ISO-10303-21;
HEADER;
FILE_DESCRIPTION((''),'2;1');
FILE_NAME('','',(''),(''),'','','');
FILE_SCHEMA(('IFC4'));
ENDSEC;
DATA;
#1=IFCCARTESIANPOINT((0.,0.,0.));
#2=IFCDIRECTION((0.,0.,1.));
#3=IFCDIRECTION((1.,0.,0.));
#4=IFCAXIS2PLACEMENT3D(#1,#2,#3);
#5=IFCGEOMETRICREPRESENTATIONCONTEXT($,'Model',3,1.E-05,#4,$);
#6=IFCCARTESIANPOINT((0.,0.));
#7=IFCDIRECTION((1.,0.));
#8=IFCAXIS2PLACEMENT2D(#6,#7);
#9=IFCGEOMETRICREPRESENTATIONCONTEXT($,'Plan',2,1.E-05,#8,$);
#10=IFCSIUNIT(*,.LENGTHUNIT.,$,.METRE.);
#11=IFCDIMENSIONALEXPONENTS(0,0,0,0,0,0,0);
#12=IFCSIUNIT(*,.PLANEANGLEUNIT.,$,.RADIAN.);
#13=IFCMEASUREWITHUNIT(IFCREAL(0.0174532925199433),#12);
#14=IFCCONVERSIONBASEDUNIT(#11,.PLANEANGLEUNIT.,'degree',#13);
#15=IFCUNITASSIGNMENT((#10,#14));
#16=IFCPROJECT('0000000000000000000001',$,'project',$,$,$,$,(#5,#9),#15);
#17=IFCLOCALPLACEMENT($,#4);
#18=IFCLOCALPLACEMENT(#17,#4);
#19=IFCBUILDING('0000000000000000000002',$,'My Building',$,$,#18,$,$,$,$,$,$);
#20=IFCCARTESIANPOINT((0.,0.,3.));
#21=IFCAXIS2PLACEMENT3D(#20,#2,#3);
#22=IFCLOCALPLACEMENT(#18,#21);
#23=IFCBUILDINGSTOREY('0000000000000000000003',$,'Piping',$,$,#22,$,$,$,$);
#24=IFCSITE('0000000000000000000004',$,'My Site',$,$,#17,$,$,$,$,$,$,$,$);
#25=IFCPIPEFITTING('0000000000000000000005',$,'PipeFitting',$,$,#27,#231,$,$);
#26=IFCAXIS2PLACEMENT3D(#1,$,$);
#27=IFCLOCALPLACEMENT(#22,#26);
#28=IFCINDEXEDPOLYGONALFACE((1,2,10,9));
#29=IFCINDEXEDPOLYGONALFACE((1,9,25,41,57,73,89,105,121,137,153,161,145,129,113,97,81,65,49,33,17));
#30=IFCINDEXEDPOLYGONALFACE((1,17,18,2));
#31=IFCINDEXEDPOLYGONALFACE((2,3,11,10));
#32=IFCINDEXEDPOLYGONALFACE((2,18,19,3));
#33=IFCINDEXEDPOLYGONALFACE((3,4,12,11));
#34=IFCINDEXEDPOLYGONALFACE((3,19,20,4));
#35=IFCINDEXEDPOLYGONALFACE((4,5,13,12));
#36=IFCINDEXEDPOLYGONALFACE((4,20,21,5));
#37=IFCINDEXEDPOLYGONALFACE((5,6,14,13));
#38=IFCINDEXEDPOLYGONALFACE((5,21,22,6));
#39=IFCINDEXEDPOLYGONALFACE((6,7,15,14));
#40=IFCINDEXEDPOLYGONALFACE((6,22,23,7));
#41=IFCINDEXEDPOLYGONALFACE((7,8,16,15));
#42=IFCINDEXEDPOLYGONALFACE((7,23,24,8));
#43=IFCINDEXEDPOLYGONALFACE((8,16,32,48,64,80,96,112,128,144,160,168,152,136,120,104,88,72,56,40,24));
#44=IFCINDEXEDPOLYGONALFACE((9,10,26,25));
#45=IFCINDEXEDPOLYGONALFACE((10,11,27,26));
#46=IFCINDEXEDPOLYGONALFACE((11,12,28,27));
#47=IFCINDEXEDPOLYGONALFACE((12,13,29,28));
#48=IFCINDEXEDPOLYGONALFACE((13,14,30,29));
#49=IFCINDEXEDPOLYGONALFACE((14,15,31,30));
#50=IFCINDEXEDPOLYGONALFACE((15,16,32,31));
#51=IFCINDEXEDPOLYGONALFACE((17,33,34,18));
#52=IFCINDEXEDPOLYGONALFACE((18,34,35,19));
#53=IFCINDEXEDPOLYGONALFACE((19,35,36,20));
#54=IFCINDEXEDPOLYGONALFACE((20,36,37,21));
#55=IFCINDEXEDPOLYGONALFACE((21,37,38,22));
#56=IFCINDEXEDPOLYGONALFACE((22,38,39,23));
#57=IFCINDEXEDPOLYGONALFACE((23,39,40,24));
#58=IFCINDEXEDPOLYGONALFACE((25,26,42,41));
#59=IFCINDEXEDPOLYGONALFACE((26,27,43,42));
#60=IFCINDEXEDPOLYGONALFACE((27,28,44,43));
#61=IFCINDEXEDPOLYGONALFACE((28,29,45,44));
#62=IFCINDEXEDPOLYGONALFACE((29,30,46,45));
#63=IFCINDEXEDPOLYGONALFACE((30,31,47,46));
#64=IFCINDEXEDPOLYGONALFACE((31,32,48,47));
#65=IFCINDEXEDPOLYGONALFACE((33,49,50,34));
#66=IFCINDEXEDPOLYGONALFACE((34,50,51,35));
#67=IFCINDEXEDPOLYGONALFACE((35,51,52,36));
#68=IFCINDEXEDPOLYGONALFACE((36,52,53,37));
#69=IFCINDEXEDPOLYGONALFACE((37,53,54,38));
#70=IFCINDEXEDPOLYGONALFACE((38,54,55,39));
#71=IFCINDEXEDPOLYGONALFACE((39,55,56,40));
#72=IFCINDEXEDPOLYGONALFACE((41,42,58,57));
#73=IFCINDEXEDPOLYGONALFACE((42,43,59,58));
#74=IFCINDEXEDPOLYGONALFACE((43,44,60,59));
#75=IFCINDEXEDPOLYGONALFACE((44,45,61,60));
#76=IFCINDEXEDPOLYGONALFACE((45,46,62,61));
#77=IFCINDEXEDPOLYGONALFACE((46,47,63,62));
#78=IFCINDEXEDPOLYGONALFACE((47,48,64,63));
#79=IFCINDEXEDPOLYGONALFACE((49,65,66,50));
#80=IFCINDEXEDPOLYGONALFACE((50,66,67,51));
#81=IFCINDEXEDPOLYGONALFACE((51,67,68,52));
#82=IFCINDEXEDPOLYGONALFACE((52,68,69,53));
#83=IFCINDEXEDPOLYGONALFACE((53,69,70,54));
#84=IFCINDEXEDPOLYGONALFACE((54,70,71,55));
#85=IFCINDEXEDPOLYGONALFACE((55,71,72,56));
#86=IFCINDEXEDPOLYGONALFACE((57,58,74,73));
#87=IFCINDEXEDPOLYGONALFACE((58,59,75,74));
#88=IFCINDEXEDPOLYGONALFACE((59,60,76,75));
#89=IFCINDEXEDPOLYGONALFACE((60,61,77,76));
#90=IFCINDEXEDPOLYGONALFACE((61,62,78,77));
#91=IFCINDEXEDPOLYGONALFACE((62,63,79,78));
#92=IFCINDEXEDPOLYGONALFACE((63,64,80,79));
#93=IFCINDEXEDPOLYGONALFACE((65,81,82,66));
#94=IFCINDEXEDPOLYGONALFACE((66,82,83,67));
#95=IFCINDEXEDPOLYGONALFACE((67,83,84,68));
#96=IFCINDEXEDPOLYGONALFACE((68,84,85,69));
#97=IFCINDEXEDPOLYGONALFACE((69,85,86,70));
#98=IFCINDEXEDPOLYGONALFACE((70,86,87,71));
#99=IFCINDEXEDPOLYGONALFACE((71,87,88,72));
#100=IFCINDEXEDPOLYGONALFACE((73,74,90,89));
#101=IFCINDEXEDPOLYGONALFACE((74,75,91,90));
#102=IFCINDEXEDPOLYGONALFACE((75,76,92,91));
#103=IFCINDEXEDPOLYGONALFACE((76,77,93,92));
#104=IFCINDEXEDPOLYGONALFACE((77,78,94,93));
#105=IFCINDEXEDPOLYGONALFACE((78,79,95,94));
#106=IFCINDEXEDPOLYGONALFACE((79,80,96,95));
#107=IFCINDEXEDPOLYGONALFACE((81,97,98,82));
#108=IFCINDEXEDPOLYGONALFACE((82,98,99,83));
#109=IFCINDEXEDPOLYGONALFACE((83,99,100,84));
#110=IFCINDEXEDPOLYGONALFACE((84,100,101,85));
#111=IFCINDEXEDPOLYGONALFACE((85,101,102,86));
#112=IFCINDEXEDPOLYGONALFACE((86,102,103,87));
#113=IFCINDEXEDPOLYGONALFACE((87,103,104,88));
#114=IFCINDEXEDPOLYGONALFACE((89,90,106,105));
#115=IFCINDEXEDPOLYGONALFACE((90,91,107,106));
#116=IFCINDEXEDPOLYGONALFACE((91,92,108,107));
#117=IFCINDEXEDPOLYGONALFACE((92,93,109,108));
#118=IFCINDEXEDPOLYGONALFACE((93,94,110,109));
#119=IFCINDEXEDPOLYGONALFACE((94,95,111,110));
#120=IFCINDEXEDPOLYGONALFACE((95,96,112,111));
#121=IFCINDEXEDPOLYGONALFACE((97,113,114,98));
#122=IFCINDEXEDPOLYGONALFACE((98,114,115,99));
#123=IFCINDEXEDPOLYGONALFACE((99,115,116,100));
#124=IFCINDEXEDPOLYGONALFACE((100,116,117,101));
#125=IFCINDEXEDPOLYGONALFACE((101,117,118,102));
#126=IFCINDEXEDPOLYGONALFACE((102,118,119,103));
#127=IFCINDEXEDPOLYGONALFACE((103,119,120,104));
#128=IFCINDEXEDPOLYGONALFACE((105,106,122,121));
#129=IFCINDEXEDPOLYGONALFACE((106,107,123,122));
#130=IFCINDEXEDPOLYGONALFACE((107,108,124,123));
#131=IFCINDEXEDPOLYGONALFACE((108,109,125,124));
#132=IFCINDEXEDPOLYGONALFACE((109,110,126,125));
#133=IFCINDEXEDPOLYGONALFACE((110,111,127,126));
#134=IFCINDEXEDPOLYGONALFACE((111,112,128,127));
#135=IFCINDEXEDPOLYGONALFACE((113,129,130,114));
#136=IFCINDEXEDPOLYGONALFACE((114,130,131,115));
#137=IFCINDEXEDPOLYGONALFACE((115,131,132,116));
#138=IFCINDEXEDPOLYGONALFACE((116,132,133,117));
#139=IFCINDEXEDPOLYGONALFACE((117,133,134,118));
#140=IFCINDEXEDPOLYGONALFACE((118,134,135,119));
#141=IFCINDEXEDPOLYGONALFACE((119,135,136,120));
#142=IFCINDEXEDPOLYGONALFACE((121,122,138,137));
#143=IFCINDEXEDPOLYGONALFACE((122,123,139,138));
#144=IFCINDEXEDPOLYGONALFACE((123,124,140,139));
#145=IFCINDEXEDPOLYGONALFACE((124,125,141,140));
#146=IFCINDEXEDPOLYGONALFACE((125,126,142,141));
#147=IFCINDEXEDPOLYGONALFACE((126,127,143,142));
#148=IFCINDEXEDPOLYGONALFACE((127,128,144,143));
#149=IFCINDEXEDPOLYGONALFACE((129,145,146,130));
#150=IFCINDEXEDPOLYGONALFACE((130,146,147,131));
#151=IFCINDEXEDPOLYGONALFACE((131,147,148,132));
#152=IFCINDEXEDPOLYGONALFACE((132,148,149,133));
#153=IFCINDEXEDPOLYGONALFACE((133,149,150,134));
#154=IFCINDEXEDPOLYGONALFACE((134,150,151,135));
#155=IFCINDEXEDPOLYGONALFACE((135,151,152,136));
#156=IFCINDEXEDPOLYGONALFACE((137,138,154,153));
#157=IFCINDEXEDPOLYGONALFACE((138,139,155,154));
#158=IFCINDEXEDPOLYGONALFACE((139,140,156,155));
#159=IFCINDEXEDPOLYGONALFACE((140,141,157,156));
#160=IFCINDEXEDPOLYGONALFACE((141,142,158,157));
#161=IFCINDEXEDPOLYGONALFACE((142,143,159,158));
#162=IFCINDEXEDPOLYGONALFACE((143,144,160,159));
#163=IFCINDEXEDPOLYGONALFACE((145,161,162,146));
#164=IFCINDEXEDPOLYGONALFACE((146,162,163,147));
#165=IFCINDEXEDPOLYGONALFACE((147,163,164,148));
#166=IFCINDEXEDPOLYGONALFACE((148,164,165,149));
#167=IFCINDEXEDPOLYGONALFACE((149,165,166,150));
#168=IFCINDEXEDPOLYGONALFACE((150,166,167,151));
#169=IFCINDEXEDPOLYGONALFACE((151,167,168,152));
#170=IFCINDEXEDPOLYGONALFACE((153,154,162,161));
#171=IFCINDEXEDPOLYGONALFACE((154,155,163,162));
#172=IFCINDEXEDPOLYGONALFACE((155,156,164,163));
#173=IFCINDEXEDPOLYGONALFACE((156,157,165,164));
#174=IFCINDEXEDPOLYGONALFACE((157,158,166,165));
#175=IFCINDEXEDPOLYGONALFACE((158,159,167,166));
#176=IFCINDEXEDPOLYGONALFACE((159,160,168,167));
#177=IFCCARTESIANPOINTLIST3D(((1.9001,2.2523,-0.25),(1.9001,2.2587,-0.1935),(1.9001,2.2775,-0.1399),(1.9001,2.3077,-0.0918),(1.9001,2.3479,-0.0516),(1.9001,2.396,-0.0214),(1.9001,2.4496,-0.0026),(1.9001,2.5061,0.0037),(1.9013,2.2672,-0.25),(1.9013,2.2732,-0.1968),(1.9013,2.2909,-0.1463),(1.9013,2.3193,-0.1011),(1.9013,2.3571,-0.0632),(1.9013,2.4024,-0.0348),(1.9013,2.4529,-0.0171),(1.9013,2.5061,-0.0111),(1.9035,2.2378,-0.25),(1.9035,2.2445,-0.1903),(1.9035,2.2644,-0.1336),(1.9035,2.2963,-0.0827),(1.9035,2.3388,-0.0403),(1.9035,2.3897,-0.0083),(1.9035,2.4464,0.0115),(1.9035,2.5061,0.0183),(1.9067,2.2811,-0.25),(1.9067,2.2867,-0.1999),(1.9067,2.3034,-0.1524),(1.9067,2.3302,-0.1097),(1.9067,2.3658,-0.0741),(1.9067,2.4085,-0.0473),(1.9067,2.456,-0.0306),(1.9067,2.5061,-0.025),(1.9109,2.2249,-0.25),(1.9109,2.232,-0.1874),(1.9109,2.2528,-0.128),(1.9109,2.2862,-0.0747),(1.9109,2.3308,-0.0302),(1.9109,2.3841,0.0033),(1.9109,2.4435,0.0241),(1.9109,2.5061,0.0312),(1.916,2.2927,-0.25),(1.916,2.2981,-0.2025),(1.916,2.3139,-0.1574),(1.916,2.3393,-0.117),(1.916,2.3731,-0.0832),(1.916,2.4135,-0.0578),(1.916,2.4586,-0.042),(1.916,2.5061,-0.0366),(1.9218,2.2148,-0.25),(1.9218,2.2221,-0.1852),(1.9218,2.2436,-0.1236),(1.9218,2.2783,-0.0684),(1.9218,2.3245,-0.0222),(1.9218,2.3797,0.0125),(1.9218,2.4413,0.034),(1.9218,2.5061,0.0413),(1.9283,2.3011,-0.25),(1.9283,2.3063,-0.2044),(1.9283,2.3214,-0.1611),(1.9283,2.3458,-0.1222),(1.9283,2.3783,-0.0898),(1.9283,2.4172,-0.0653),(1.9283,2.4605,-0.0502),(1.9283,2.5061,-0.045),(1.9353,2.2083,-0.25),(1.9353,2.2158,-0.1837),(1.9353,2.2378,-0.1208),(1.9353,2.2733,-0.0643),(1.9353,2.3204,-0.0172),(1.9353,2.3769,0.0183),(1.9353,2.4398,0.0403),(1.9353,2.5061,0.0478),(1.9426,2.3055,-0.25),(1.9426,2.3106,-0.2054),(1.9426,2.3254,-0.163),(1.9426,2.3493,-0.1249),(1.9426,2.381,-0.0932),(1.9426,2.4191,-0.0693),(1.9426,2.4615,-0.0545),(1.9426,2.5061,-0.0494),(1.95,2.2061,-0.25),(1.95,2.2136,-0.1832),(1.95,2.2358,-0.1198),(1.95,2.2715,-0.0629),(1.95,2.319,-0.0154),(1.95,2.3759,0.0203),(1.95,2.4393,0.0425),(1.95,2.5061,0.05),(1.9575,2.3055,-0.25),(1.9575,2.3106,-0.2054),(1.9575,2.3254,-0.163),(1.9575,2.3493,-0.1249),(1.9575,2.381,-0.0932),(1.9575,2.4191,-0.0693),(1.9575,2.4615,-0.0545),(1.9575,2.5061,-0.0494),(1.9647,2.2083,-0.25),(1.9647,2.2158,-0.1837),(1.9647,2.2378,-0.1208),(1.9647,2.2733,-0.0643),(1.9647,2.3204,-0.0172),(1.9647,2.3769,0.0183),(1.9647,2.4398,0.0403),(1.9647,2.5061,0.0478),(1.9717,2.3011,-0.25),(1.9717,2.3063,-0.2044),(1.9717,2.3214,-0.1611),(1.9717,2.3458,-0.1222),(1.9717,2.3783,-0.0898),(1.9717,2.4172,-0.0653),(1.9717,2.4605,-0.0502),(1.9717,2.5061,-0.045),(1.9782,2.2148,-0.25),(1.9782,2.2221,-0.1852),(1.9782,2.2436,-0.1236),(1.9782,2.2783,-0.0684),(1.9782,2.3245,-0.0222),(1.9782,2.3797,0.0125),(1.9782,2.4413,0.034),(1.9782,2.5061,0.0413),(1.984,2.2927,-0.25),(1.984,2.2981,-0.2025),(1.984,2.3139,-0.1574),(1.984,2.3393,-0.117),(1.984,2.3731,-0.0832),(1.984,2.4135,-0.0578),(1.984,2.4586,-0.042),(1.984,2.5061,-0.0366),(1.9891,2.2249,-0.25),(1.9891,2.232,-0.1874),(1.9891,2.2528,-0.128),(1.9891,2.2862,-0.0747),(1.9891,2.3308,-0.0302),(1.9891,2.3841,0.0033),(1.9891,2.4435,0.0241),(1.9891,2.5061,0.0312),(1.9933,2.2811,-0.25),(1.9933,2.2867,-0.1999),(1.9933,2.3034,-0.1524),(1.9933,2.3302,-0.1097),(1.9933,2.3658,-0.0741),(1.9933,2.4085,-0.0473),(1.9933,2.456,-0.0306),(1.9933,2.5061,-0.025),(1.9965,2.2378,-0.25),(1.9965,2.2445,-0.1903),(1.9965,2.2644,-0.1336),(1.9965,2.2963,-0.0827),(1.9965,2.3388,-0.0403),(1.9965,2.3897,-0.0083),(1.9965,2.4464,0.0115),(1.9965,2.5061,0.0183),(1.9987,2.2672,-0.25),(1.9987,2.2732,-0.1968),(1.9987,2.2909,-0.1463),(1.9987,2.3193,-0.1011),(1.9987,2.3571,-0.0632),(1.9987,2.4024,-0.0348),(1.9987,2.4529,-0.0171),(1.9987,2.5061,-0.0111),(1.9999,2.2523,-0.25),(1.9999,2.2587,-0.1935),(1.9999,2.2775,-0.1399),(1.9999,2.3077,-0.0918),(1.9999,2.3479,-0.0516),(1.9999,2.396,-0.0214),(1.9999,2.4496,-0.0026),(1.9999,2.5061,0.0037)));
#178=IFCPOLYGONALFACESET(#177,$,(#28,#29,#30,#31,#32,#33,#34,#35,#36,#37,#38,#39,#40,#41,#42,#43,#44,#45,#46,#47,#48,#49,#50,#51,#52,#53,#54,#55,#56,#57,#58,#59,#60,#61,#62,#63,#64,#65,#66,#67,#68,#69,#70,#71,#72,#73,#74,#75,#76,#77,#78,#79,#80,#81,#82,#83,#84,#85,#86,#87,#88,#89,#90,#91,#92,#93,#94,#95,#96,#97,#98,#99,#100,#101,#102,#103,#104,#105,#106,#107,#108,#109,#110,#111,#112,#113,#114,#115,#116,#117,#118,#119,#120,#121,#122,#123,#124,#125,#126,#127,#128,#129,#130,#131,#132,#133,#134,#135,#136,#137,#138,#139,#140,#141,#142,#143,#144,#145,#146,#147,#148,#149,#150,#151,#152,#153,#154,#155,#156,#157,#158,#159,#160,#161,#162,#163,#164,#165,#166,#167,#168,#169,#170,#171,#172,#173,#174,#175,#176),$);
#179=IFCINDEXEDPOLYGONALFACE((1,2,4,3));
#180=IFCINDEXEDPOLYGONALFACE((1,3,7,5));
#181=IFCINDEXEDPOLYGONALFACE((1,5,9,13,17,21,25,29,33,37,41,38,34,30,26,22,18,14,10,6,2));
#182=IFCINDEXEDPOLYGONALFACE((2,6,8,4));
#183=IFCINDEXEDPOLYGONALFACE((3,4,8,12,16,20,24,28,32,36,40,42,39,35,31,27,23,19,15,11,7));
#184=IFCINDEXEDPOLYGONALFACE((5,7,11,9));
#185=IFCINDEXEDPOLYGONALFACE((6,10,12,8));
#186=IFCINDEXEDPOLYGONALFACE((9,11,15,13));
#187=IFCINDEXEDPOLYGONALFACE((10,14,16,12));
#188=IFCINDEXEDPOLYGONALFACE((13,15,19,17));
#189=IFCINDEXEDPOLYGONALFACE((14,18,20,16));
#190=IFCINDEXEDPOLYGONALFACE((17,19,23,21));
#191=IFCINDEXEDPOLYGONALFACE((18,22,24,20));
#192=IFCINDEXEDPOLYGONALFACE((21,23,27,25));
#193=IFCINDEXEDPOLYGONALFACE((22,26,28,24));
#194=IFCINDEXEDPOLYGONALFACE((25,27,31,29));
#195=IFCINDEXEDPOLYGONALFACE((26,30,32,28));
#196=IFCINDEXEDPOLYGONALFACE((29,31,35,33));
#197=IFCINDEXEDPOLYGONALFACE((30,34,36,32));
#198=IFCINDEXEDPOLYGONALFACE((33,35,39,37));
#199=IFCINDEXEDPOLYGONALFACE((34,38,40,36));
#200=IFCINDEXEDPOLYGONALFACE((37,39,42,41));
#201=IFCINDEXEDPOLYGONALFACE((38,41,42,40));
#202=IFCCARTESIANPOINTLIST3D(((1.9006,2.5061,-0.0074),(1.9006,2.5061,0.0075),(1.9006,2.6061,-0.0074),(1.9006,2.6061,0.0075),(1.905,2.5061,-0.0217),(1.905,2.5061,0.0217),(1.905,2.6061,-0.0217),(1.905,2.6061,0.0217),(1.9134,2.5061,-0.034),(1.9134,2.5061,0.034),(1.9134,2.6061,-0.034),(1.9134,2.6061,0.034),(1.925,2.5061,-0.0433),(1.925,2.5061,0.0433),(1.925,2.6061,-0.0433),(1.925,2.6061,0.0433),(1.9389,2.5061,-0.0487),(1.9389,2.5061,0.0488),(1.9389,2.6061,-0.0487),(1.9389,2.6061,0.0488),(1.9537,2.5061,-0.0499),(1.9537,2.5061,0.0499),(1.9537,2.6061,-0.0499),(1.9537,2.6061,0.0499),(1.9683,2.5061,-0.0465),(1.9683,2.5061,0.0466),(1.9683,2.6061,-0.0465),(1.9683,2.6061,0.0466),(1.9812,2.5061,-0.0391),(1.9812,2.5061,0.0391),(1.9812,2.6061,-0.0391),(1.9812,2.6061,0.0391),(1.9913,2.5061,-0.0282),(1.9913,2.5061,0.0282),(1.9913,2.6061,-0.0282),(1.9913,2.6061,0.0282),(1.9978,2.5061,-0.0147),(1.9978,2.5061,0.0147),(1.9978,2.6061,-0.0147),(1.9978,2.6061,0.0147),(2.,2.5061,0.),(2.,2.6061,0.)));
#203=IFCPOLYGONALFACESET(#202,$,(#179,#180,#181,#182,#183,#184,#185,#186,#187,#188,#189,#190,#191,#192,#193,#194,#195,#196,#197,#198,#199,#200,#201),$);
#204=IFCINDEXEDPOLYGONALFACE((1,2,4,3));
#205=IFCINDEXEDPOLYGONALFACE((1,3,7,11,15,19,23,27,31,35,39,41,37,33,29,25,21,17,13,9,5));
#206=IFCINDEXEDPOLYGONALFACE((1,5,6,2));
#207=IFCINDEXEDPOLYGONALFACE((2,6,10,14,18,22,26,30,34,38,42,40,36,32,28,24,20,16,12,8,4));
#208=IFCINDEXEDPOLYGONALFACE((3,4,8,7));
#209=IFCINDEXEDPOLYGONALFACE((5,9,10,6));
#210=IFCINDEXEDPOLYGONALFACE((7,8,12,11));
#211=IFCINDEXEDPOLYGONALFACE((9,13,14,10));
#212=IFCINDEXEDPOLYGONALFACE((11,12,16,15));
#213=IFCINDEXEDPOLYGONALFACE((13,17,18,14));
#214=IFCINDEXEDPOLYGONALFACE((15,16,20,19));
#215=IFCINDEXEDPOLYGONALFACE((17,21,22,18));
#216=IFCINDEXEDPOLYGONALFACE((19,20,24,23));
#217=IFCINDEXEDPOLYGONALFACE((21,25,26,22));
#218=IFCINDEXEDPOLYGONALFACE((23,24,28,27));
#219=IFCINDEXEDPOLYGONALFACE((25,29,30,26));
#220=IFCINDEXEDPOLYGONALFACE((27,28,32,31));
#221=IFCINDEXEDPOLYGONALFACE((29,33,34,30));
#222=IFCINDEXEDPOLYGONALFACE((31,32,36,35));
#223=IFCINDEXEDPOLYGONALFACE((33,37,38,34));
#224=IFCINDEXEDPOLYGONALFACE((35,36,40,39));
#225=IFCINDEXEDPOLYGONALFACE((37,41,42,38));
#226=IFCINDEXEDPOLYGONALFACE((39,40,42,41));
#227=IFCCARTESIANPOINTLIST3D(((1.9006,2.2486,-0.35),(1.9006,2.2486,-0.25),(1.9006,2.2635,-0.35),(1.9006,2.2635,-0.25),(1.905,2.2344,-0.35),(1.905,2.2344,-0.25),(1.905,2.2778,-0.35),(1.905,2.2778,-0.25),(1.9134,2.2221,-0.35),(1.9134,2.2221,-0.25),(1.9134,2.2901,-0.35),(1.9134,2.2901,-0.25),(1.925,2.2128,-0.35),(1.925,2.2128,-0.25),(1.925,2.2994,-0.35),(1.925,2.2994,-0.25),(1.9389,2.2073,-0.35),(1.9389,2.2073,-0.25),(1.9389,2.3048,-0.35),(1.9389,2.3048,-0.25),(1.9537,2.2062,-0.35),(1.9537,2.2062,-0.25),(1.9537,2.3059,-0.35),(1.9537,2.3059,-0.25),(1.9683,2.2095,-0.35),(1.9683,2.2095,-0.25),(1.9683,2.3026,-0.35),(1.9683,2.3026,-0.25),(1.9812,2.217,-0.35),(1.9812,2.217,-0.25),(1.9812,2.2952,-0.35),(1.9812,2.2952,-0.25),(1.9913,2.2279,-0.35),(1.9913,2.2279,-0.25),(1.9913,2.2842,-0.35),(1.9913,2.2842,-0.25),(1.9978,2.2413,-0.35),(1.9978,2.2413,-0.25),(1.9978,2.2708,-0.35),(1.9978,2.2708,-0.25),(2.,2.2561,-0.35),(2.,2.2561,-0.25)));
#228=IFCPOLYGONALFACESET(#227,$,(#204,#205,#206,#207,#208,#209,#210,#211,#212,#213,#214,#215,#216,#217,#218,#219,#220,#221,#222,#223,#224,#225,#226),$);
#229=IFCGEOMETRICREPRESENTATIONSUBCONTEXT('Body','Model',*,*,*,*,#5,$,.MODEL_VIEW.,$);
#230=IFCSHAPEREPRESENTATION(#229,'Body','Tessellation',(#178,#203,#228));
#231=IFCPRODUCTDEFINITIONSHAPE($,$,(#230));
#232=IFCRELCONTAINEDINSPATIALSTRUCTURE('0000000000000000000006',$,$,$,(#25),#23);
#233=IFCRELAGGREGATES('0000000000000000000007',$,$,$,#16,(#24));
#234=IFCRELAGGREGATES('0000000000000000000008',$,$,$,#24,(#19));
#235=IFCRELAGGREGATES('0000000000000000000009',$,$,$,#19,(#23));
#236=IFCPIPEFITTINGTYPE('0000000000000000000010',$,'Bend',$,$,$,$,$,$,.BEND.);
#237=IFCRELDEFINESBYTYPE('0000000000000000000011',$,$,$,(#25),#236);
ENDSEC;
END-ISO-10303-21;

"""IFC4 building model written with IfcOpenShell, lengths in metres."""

from ifc_helpers import new_model, entity, si_unit, converted_unit, frame, origin_with_axes, origin_2d_with_axis, place, context, subcontext, project, spatial, circle, extrude, source, transform, mapped, type_object, type_shapes, element, save


model = new_model("IFC4")

# Units and contexts
model_context = context("Model", 3, precision=1e-05, world=origin_with_axes())
plan_context = context("Plan", 2, precision=1e-05, world=origin_2d_with_axis())
body_context = subcontext(model_context, "Body", "Model", "MODEL_VIEW")
ifc_project = project(units=[si_unit("LENGTHUNIT", "METRE"), converted_unit("PLANEANGLEUNIT", "degree", entity("IfcReal", 0.0174532925199433), si_unit("PLANEANGLEUNIT", "RADIAN"), dimensions=[0, 0, 0, 0, 0, 0, 0])], contexts=[model_context, plan_context])

# Site, building, storey
site_placement = place(None, origin_with_axes())
site = spatial("IfcSite", under=ifc_project, at=site_placement, Name="My Site")
building_placement = place(site_placement, origin_with_axes())
building = spatial("IfcBuilding", under=site, at=building_placement, Name="My Building")
storey_placement = place(building_placement, frame((0.0, 0.0, 3.0), z_axis=(0.0, 0.0, 1.0), x_axis=(1.0, 0.0, 0.0)))
storey = spatial("IfcBuildingStorey", under=building, at=storey_placement, Name="Piping")

# Pipe fitting
pipe_fitting_type = type_object("IfcPipeFittingType", Name="Bend", PredefinedType="BEND")
shared_shape = source(origin_with_axes(), body_context, "Body", "SolidModel", [
    entity("IfcSweptDiskSolid", entity("IfcIndexedPolyCurve", entity("IfcCartesianPointList3D", [[0.0, 0.0, 0.1], [0.0, -0.0732, 0.2768], [0.0, -0.25, 0.35]]), [entity("IfcArcIndex", [1, 2, 3])]), 0.05),
    extrude(circle(Radius=0.05), origin_with_axes(), (0.0, 0.0, 1.0), 0.1),
    extrude(circle(Radius=0.05), frame((0.0, -0.25, 0.35), z_axis=(0.0, -1.0, 0.0), x_axis=(1.0, 0.0, 0.0)), (0.0, 0.0, 1.0), 0.1),
])
type_shapes(pipe_fitting_type, [shared_shape])
for number, where, z_axis, x_axis, name in (
    (1, (1.95, 2.6061, 0.0), (0.0, -1.0, 0.0), (1.0, 0.0, 0.0), "PipeFitting"),
):
    element("IfcPipeFitting", number, at=place(storey_placement, frame(where, z_axis=z_axis, x_axis=x_axis)), inside=storey, type_object=pipe_fitting_type, Name=name, context=body_context, shape_type="MappedRepresentation", body=[
        mapped(shared_shape, transform((0.0, 0.0, 0.0), x_axis=(1.0, 0.0, 0.0), y_axis=(0.0, 1.0, 0.0), z_axis=(0.0, 0.0, 1.0), scale=1.0)),
    ])

save(model, "model.ifc")
